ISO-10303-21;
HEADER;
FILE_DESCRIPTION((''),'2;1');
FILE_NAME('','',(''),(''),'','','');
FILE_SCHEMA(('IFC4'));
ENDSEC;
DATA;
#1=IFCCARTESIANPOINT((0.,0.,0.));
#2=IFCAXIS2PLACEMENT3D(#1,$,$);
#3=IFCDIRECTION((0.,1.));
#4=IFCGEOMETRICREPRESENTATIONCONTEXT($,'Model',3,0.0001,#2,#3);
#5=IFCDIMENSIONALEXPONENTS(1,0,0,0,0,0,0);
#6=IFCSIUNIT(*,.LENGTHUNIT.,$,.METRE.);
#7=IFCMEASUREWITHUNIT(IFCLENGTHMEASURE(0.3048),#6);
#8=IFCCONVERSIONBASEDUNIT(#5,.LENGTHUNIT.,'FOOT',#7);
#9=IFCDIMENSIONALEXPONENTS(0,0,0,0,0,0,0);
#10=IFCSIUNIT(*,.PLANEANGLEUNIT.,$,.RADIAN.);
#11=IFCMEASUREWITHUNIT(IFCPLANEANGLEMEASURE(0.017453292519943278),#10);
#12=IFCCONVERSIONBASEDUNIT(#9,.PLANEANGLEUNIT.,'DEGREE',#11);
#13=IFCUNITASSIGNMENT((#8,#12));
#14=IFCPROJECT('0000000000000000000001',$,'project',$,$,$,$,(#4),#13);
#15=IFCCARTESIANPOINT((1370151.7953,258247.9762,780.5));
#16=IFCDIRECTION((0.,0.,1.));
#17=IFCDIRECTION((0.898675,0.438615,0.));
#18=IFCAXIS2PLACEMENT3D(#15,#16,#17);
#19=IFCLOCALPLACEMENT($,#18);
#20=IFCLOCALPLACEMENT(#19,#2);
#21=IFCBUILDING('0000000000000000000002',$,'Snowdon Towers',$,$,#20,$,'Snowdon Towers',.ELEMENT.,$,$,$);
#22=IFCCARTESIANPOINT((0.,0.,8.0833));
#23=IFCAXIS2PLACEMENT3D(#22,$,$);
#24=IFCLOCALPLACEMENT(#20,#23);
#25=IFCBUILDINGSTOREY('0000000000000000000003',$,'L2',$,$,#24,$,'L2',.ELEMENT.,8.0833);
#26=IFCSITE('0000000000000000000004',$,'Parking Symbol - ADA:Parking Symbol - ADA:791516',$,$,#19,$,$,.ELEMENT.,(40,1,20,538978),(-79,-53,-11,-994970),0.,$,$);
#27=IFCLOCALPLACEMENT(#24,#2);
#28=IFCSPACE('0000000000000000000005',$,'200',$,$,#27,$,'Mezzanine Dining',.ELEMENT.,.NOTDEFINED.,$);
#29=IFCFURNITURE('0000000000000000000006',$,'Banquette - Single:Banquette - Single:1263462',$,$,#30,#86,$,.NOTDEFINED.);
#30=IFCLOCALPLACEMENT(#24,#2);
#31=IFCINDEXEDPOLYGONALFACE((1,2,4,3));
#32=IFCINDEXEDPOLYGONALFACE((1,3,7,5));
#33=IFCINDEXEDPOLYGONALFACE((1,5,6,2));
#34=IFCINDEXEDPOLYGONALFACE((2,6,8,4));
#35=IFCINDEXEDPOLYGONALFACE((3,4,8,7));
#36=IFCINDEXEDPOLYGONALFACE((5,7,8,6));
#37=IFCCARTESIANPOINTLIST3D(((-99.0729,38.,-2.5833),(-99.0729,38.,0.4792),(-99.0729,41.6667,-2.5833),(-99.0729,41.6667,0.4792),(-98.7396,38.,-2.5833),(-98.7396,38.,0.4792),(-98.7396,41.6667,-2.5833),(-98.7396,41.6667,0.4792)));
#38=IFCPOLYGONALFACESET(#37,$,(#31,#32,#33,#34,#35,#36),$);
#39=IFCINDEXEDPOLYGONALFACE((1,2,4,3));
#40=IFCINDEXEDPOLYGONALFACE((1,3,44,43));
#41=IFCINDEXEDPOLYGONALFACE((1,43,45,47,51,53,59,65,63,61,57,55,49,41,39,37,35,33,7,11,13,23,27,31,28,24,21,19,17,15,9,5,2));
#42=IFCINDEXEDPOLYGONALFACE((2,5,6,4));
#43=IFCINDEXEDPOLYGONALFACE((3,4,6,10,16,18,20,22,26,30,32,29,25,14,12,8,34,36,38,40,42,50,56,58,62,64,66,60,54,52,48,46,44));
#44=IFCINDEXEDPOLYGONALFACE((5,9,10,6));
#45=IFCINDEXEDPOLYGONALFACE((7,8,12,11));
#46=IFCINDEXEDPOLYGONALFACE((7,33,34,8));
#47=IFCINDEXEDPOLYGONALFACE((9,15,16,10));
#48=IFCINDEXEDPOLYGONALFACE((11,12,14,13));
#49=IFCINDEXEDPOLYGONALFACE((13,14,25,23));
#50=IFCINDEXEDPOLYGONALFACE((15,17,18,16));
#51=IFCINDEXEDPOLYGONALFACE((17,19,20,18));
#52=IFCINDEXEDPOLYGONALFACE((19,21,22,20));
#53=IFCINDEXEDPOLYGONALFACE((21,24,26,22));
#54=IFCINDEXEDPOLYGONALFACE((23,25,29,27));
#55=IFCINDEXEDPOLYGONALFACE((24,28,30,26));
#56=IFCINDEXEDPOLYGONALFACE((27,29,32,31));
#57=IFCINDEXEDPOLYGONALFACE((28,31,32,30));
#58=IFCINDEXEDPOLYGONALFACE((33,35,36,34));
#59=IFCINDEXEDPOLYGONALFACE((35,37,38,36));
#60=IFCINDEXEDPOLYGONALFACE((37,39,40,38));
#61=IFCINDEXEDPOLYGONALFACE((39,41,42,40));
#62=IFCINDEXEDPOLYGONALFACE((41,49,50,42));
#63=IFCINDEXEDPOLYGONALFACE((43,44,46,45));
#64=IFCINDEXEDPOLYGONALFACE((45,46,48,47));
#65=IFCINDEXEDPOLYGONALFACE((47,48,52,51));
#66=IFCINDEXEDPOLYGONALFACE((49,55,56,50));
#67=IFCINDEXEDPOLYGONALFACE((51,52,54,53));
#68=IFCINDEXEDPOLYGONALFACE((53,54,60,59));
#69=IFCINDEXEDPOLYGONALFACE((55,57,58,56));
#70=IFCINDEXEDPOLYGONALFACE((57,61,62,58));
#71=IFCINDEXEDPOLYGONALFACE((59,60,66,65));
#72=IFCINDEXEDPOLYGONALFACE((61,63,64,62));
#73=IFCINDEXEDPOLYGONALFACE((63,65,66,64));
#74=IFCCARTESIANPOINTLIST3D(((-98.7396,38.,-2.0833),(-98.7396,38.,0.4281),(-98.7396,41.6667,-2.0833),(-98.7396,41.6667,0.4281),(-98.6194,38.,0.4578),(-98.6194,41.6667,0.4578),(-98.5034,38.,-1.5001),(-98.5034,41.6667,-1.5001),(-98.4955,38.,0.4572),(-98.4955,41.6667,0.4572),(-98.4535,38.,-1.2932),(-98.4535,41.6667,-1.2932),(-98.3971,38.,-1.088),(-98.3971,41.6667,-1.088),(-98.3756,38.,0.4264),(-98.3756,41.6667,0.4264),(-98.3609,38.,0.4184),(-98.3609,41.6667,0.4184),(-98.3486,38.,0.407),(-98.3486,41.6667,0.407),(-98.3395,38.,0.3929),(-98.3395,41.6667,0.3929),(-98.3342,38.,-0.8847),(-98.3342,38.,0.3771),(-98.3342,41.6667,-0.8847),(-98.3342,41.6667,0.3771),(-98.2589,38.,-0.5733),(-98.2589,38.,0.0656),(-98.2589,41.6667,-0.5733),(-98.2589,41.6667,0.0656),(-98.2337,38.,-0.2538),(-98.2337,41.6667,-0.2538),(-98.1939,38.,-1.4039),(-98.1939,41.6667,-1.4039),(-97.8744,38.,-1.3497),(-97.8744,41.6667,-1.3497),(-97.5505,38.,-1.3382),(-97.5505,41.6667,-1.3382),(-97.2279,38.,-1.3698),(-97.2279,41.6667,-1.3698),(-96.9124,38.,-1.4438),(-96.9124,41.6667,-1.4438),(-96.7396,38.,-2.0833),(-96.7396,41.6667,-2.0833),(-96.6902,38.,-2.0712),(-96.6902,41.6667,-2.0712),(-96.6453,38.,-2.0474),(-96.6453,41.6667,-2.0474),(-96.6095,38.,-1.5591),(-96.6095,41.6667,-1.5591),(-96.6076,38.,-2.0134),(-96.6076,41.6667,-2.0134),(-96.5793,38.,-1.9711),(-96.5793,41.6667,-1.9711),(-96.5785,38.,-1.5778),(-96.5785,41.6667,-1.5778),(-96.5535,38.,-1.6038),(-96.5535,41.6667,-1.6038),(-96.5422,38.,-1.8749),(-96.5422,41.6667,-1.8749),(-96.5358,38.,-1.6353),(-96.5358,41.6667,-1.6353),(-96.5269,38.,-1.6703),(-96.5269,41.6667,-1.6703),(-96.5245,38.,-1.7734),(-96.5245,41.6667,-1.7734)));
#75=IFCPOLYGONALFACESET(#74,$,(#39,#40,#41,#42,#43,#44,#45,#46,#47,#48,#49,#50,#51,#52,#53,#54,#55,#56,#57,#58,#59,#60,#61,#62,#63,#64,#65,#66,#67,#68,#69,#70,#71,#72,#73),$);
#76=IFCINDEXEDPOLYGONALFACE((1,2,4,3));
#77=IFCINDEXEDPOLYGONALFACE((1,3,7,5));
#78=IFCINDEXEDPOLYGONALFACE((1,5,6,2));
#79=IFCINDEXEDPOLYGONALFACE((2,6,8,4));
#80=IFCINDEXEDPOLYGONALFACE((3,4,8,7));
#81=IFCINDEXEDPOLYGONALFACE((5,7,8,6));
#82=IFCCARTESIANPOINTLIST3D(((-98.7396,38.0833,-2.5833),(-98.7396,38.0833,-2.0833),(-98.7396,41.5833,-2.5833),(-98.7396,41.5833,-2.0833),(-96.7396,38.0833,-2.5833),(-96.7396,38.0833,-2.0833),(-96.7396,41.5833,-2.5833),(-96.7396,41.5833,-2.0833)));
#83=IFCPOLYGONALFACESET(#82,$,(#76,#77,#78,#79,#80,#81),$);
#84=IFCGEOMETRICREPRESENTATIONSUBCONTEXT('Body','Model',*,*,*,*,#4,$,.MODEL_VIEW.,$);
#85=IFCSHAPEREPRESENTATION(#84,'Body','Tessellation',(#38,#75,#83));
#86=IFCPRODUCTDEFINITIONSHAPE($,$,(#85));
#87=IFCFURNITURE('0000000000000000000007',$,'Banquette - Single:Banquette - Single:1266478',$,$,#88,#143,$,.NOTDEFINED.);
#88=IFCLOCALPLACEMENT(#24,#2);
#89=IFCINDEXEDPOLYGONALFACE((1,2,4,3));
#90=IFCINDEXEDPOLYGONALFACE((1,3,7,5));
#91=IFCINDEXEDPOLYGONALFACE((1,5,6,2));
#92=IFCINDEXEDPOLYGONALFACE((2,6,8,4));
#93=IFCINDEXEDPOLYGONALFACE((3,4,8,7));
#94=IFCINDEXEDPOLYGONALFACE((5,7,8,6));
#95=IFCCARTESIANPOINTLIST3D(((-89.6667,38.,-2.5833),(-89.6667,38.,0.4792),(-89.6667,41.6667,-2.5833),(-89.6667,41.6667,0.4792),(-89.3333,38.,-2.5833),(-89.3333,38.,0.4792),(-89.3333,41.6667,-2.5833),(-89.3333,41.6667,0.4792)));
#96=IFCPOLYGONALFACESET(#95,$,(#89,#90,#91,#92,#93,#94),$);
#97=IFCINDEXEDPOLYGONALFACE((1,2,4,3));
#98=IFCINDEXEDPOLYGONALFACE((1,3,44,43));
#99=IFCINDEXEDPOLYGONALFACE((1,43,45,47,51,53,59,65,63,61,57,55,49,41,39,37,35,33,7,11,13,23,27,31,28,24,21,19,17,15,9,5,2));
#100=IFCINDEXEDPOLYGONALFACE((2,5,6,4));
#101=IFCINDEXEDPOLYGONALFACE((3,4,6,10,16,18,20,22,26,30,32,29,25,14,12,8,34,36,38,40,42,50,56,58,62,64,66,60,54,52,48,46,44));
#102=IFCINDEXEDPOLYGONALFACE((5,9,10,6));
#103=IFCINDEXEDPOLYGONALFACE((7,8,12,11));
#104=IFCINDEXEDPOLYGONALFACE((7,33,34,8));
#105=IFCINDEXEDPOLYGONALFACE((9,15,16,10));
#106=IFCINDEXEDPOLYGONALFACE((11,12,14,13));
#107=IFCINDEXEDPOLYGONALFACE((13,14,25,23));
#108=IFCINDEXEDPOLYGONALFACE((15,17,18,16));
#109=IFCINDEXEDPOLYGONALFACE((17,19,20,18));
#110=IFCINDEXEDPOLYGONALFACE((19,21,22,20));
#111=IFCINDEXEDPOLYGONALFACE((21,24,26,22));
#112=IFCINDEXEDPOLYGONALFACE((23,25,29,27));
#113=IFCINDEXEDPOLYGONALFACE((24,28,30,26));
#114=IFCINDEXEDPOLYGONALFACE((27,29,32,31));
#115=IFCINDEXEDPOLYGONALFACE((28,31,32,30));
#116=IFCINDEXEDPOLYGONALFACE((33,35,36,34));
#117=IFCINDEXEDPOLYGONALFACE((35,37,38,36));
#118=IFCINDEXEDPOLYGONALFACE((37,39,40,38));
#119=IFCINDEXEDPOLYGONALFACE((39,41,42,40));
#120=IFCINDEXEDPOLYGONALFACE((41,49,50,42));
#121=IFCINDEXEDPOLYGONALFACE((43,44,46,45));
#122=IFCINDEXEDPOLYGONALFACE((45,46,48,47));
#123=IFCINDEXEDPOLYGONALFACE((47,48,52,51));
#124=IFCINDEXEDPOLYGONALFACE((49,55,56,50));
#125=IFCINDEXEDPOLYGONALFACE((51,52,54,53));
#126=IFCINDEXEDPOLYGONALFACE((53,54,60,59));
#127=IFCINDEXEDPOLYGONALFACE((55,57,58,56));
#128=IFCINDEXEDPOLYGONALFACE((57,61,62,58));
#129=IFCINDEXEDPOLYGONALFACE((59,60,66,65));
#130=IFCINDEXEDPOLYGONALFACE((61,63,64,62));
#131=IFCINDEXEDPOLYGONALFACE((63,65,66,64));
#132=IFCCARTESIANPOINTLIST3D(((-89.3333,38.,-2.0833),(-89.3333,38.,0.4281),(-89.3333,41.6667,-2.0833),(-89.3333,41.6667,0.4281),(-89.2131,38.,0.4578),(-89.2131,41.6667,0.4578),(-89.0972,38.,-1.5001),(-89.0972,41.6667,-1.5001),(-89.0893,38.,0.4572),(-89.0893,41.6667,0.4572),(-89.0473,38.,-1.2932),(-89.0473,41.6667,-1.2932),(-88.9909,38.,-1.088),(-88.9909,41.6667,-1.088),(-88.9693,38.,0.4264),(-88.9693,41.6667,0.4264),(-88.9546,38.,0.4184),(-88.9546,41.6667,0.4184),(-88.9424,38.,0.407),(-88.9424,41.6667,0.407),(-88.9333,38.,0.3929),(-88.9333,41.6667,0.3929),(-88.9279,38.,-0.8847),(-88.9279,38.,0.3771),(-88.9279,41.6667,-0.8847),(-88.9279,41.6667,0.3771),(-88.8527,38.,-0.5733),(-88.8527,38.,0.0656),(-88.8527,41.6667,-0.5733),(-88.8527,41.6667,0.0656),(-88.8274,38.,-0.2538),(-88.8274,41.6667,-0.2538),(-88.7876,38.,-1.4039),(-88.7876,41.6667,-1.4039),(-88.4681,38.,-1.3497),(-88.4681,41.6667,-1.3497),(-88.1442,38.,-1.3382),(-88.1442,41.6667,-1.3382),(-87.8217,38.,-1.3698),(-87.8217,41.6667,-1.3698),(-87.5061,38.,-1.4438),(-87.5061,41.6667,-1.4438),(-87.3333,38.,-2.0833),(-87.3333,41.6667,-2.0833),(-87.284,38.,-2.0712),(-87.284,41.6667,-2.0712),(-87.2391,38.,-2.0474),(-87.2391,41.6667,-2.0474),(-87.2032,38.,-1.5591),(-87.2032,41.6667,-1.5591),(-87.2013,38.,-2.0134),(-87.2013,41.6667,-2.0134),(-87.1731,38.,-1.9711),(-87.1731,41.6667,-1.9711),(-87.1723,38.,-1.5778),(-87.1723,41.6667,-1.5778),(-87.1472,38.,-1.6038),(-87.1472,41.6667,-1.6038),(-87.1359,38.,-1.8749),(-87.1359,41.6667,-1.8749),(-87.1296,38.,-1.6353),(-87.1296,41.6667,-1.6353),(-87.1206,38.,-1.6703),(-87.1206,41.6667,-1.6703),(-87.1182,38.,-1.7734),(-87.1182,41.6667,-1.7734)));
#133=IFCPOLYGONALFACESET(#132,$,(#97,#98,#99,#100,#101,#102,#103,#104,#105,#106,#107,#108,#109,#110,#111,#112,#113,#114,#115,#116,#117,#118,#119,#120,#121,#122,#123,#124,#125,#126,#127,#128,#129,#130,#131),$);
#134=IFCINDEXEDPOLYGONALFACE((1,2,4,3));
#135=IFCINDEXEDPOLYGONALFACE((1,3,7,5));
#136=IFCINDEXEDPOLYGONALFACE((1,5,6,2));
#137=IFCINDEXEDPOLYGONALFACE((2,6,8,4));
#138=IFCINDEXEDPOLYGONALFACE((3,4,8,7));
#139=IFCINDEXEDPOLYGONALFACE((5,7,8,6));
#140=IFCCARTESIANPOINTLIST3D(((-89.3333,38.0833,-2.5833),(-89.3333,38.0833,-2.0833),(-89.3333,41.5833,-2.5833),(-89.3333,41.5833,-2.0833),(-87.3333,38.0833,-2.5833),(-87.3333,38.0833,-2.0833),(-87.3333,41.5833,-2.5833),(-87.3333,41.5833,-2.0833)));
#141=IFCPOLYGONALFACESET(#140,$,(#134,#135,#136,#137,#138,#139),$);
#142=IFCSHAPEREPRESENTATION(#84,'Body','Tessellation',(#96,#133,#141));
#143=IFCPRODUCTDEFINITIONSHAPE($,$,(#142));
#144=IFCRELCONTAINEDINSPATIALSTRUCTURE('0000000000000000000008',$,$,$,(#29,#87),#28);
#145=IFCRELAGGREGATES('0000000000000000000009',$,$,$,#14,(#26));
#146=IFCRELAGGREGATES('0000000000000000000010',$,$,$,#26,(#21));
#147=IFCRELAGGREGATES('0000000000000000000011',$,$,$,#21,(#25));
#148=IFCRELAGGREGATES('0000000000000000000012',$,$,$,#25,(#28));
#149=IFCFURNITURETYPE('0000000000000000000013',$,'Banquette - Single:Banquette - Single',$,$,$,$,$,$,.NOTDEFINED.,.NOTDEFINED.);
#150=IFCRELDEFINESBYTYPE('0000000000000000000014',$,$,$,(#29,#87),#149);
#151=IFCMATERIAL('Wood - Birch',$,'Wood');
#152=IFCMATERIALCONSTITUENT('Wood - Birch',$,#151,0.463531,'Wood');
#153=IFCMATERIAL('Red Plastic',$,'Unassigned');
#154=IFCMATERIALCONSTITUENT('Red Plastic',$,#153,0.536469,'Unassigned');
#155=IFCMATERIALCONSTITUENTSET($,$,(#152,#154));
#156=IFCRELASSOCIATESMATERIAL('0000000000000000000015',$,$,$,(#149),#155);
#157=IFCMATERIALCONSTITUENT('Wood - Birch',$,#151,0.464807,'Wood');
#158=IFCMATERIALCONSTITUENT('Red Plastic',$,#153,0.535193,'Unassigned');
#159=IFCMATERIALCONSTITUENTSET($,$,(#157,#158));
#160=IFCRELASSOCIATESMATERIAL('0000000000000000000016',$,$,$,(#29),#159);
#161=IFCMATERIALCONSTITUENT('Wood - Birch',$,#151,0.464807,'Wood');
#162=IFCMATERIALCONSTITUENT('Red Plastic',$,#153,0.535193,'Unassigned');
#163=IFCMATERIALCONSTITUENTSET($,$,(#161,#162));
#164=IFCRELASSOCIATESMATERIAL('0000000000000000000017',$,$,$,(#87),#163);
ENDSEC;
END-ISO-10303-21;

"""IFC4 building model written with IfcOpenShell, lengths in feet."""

from ifc_helpers import new_model, entity, si_unit, converted_unit, direction, frame, origin, place, context, subcontext, project, spatial, line, arc, indexed_curve, outline, extrude, source, transform, mapped, material, constituent, constituent_set, type_object, type_shapes, element, save


model = new_model("IFC4")

# Units and contexts
model_context = context("Model", 3, precision=0.0001, world=origin(), true_north=direction((0.0, 1.0)))
body_context = subcontext(model_context, "Body", "Model", "MODEL_VIEW")
ifc_project = project(units=[converted_unit("LENGTHUNIT", "FOOT", entity("IfcLengthMeasure", 0.3048), si_unit("LENGTHUNIT", "METRE"), dimensions=[1, 0, 0, 0, 0, 0, 0]), converted_unit("PLANEANGLEUNIT", "DEGREE", entity("IfcPlaneAngleMeasure", 0.017453292519943278), si_unit("PLANEANGLEUNIT", "RADIAN"), dimensions=[0, 0, 0, 0, 0, 0, 0])], contexts=[model_context])

# Site, building, storey
site_placement = place(None, frame((1370151.7953, 258247.9762, 780.5), z_axis=(0.0, 0.0, 1.0), x_axis=(0.898675, 0.438615, 0.0)))
site = spatial("IfcSite", under=ifc_project, at=site_placement, Name="Parking Symbol - ADA:Parking Symbol - ADA:791516", CompositionType="ELEMENT", RefLatitude=(40, 1, 20, 538978), RefLongitude=(-79, -53, -11, -994970), RefElevation=0.0)
building_placement = place(site_placement, origin())
building = spatial("IfcBuilding", under=site, at=building_placement, Name="Snowdon Towers", LongName="Snowdon Towers", CompositionType="ELEMENT")
storey_placement = place(building_placement, frame((0.0, 0.0, 8.0833)))
storey = spatial("IfcBuildingStorey", under=building, at=storey_placement, Name="L2", LongName="L2", CompositionType="ELEMENT", Elevation=8.0833)

# Shared definitions
space_1_placement = place(storey_placement, origin())
space_1 = spatial("IfcSpace", under=storey, at=space_1_placement, Name="200", LongName="Mezzanine Dining", CompositionType="ELEMENT", PredefinedType="NOTDEFINED")

# Furniture
ifc_material_1 = material(Name="Wood - Birch", Category="Wood")
ifc_material_2 = material(Name="Red Plastic", Category="Unassigned")
ifc_constituent_1 = constituent(ifc_material_1, Name="Wood - Birch", Category="Wood", fraction=0.464807)
ifc_constituent_2 = constituent(ifc_material_2, Name="Red Plastic", Category="Unassigned", fraction=0.535193)
ifc_constituent_set_1 = constituent_set(constituents=[ifc_constituent_1, ifc_constituent_2])
ifc_constituent_3 = constituent(ifc_material_1, Name="Wood - Birch", Category="Wood", fraction=0.463531)
ifc_constituent_4 = constituent(ifc_material_2, Name="Red Plastic", Category="Unassigned", fraction=0.536469)
ifc_constituent_set_2 = constituent_set(constituents=[ifc_constituent_3, ifc_constituent_4])
furniture_type_1 = type_object("IfcFurnitureType", Name="Banquette - Single:Banquette - Single", AssemblyPlace="NOTDEFINED", PredefinedType="NOTDEFINED", material=ifc_constituent_set_2)
shared_shape_1 = source(origin(), body_context, "Body", "SweptSolid", [
    extrude(outline(indexed_curve([(-1.8333, -0.1667), (1.8333, -0.1667), (1.8333, 0.1667), (-1.8333, 0.1667), (-1.8333, -0.1667)], self_intersect=False)), frame((-0.1667, -1.8333, 0.0), z_axis=(0.0, 0.0, 1.0), x_axis=(0.0, -1.0, 0.0)), (0.0, 0.0, 1.0), 3.0625),
    extrude(outline(indexed_curve([(1.1689, 0.9191), (1.1029, 0.9954), (1.0086, 1.0313), (-0.9914, 1.0313), (-0.9914, -1.4801), (-0.8092, -1.5134), (-0.6274, -1.4784), (-0.6004, -1.459), (-0.586, -1.4291), (-0.4855, -0.7982), (-0.586, -0.1673), (-0.678, 0.1384), (-0.7552, 0.4481), (0.1977, 0.2862), (1.1387, 0.507), (1.1947, 0.5517), (1.2213, 0.6183), (1.2173, 0.7725)], segments=[arc(1, 2, 3), line(3, 4, 5), arc(5, 6, 7), arc(7, 8, 9), arc(9, 10, 11), arc(11, 12, 13), arc(13, 14, 15), arc(15, 16, 17), arc(17, 18, 1)], self_intersect=False)), frame((0.9914, -3.6667, 1.5313), z_axis=(0.0, 1.0, 0.0), x_axis=(1.0, 0.0, 0.0)), (0.0, 0.0, 1.0), 3.6667),
    extrude(outline(indexed_curve([(-1.0, -1.75), (1.0, -1.75), (1.0, 1.75), (-1.0, 1.75), (-1.0, -1.75)], self_intersect=False)), frame((1.0, -1.8333, 0.0), z_axis=(0.0, 0.0, 1.0), x_axis=(-1.0, 0.0, 0.0)), (0.0, 0.0, 1.0), 0.5),
])
type_shapes(furniture_type_1, [shared_shape_1])
furniture_1_placement = place(space_1_placement, frame((-98.7396, 41.6667, -2.5833)))
element("IfcFurniture", 1, at=furniture_1_placement, inside=space_1, type_object=furniture_type_1, material=ifc_constituent_set_1, Name="Banquette - Single:Banquette - Single:1263462", PredefinedType="NOTDEFINED", context=body_context, shape_type="MappedRepresentation", body=[
    mapped(shared_shape_1, transform((0.0, 0.0, 0.0), scale=1.0)),
])
ifc_constituent_5 = constituent(ifc_material_1, Name="Wood - Birch", Category="Wood", fraction=0.464807)
ifc_constituent_6 = constituent(ifc_material_2, Name="Red Plastic", Category="Unassigned", fraction=0.535193)
ifc_constituent_set_3 = constituent_set(constituents=[ifc_constituent_5, ifc_constituent_6])
furniture_2_placement = place(space_1_placement, frame((-89.3333, 41.6667, -2.5833)))
element("IfcFurniture", 2, at=furniture_2_placement, inside=space_1, type_object=furniture_type_1, material=ifc_constituent_set_3, Name="Banquette - Single:Banquette - Single:1266478", PredefinedType="NOTDEFINED", context=body_context, shape_type="MappedRepresentation", body=[
    mapped(shared_shape_1, transform((0.0, 0.0, 0.0), scale=1.0)),
])

save(model, "model.ifc")
